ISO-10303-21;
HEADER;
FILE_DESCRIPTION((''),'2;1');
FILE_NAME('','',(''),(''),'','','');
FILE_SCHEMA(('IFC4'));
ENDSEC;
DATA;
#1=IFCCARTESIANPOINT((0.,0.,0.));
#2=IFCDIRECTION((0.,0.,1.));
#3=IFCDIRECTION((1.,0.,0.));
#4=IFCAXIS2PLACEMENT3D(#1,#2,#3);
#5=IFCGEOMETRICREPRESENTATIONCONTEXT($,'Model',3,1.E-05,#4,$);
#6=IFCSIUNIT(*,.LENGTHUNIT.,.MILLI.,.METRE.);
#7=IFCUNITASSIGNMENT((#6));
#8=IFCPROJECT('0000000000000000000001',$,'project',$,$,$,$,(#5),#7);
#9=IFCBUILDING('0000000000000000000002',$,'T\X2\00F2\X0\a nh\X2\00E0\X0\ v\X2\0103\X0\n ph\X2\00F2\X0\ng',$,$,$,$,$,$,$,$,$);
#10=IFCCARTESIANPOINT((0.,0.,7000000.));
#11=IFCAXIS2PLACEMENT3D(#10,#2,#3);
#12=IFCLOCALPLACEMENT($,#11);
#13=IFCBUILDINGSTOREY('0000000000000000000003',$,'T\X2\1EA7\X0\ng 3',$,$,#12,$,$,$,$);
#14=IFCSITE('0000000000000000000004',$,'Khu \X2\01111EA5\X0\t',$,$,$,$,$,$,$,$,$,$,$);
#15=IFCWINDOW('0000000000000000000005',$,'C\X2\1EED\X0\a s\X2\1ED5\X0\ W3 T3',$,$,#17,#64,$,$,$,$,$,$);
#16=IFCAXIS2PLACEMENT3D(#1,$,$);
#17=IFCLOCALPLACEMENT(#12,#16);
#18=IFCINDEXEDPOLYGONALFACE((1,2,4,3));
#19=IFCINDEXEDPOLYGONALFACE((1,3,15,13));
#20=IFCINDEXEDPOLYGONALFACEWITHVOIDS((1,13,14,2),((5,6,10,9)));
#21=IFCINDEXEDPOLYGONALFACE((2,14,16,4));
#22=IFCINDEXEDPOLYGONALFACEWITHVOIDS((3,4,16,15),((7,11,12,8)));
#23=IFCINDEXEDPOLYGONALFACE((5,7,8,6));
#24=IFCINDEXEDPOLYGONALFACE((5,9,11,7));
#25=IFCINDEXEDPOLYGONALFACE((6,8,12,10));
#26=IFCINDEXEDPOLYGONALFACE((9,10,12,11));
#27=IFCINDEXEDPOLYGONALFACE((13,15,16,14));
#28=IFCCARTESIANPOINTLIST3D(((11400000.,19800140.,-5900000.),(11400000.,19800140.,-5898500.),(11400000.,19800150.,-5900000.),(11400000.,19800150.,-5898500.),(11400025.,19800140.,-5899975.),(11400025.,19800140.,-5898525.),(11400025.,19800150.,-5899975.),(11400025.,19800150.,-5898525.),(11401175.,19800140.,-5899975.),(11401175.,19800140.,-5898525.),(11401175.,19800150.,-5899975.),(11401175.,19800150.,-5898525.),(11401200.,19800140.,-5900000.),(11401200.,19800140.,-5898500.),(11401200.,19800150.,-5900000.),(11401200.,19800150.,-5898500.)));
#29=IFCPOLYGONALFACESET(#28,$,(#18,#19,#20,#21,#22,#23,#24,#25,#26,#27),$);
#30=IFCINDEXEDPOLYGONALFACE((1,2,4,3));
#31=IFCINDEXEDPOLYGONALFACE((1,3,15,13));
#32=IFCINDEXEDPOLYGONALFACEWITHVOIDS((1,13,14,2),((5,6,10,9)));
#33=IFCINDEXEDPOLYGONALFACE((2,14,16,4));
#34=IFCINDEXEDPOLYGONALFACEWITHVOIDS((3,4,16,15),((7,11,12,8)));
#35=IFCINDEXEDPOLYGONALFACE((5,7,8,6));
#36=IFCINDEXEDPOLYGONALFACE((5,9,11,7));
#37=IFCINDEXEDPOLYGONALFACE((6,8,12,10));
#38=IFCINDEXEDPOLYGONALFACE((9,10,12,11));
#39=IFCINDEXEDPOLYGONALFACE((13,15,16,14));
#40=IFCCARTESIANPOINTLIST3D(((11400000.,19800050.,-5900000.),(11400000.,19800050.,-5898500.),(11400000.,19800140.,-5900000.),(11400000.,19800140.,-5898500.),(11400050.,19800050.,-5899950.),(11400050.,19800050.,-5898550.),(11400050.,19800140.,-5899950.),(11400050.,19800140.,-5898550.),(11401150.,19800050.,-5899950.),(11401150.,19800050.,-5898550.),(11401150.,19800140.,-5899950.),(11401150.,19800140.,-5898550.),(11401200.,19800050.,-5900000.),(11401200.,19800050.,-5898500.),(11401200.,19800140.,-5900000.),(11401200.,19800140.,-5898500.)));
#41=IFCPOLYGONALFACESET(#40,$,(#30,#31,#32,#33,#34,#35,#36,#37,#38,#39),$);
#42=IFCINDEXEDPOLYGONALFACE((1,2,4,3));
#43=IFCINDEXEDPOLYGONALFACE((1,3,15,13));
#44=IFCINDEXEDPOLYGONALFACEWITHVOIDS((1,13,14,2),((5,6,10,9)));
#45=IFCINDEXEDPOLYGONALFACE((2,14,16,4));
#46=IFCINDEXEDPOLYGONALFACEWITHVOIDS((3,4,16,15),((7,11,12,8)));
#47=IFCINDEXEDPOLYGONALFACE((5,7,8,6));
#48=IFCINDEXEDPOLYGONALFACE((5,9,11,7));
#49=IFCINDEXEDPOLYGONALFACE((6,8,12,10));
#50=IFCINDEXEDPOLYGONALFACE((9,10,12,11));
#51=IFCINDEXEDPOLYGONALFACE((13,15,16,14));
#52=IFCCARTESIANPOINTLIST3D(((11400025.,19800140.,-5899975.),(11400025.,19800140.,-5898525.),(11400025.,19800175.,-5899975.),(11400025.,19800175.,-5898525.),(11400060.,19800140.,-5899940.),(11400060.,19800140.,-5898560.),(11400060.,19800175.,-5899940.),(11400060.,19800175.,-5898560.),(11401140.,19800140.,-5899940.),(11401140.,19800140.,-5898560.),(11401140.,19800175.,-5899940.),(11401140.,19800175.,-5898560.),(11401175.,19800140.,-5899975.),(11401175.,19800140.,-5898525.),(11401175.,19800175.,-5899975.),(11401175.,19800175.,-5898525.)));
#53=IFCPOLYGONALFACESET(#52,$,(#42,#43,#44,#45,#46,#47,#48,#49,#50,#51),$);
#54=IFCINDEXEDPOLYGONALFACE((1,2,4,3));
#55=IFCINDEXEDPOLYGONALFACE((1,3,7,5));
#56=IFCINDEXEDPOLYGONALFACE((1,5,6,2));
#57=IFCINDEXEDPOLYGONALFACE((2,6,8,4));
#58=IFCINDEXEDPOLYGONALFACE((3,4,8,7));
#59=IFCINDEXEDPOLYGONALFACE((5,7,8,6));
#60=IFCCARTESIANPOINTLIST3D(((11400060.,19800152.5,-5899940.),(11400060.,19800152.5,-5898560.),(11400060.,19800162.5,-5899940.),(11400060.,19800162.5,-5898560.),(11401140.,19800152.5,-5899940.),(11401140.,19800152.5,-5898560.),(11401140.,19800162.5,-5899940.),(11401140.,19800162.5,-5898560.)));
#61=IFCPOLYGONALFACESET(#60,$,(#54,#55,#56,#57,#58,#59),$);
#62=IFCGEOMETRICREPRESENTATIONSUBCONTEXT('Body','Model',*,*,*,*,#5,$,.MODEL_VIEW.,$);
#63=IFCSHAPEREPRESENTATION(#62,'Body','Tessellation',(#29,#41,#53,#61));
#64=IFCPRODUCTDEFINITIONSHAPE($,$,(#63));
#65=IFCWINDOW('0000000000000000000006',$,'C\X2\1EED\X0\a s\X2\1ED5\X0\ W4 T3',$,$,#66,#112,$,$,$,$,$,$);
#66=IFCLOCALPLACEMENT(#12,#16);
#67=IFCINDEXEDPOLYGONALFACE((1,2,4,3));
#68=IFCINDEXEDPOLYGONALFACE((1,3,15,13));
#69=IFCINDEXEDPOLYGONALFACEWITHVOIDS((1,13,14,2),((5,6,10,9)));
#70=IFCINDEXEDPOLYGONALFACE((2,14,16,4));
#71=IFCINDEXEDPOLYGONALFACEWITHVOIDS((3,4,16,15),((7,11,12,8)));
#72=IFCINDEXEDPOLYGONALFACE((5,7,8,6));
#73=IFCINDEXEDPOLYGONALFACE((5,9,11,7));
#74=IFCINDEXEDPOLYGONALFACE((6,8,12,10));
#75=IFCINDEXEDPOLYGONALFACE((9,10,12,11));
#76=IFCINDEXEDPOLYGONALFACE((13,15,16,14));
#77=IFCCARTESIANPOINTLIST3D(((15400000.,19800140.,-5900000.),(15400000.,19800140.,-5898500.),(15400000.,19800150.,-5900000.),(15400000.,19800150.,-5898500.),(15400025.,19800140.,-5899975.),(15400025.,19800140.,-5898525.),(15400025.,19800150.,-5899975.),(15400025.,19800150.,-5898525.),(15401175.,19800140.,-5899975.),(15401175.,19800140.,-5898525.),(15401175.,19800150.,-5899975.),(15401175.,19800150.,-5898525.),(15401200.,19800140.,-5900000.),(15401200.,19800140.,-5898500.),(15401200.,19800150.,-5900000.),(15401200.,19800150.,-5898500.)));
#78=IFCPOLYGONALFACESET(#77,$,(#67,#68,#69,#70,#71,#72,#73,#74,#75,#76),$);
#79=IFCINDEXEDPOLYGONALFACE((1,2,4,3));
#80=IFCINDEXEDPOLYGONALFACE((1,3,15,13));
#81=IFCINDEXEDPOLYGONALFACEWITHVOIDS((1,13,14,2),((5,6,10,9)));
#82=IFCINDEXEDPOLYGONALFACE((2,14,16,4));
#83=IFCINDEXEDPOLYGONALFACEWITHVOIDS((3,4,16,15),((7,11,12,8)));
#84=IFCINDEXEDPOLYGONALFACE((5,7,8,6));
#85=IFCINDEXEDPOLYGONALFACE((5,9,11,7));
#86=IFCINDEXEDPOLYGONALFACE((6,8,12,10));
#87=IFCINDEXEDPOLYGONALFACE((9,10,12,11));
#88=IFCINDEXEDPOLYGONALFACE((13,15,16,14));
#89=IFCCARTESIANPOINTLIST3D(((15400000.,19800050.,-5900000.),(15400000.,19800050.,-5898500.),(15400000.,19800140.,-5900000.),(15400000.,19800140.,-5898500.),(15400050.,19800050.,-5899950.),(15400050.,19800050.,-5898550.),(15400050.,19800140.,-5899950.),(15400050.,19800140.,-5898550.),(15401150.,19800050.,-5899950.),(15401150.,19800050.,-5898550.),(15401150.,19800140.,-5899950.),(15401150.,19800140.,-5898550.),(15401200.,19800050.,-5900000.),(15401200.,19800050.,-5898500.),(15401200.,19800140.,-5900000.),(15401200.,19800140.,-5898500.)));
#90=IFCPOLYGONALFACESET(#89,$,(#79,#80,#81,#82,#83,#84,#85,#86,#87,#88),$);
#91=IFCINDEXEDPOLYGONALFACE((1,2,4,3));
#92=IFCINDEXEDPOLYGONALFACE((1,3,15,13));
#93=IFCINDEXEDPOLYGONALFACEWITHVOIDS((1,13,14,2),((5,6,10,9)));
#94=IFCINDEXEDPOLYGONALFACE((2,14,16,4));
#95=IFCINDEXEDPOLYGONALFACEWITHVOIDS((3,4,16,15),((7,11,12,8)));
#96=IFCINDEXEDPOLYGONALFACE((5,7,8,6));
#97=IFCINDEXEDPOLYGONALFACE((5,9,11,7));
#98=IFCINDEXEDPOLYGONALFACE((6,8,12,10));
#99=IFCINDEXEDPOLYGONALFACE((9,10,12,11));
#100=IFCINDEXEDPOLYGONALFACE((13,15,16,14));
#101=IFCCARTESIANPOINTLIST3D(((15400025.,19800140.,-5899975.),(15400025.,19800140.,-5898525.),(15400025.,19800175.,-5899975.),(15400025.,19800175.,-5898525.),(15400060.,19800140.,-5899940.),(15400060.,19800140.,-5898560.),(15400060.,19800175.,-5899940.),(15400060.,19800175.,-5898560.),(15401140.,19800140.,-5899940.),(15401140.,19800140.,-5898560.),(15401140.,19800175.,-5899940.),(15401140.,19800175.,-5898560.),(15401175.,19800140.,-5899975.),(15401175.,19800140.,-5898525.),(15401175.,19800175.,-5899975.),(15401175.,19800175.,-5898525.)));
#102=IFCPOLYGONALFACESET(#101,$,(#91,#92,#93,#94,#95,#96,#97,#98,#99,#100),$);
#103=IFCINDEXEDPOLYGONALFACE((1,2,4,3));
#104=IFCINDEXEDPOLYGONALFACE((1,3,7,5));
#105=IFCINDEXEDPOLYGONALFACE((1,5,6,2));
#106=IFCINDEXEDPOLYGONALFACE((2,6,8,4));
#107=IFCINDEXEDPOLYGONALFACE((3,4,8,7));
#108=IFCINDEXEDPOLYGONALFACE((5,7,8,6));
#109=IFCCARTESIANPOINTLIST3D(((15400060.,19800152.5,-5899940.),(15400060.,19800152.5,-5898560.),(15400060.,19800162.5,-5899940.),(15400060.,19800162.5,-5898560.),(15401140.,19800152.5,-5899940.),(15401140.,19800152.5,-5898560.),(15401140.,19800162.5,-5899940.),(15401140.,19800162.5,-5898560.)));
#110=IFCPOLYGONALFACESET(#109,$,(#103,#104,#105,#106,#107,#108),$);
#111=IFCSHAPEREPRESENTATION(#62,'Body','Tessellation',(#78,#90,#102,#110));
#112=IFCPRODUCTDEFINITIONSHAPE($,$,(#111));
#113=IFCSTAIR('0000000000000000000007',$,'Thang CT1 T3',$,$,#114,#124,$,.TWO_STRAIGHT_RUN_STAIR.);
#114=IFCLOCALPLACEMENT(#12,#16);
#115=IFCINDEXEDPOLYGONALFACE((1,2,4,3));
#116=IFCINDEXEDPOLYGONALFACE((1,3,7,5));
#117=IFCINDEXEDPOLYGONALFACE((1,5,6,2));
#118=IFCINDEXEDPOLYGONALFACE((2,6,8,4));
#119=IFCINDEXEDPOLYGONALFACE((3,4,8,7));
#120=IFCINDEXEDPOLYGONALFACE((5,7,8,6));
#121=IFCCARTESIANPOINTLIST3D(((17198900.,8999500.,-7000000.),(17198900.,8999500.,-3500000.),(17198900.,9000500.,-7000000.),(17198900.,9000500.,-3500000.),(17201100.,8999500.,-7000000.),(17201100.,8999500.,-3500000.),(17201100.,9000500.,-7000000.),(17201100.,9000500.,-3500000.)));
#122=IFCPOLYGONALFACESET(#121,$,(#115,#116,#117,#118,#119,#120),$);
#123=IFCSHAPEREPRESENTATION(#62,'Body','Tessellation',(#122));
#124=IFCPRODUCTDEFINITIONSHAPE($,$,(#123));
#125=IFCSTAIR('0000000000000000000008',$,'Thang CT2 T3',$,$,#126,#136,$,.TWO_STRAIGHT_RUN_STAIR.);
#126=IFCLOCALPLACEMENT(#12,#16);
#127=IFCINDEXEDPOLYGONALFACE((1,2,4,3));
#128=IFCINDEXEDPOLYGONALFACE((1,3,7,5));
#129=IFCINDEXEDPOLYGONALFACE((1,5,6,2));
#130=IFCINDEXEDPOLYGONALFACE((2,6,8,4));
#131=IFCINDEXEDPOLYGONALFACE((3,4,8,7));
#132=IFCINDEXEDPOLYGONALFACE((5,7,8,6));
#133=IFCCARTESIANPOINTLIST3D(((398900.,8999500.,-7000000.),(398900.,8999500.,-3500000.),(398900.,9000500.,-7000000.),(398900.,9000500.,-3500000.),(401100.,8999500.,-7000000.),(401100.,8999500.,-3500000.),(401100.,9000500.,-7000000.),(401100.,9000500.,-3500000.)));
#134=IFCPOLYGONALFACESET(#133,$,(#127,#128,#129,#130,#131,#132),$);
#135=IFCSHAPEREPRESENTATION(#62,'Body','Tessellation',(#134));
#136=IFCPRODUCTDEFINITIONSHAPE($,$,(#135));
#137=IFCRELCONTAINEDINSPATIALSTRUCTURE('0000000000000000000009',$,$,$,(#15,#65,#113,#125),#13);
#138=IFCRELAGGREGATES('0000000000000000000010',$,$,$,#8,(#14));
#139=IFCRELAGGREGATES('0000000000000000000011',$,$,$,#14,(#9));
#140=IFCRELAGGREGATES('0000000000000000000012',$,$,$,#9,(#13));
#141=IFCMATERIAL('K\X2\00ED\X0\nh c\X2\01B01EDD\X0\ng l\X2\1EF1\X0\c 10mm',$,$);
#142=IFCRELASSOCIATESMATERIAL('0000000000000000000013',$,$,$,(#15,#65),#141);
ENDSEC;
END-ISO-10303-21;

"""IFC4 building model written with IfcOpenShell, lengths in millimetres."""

from ifc_helpers import new_model, entity, si_unit, frame, origin_with_axes, place, context, subcontext, project, spatial, line, indexed_curve, outline, extrude, material, element, save


model = new_model("IFC4")

# Units and contexts
model_context = context("Model", 3, precision=1e-05, world=origin_with_axes())
body_context = subcontext(model_context, "Body", "Model", "MODEL_VIEW")
ifc_project = project(units=[si_unit("LENGTHUNIT", "METRE", prefix="MILLI")], contexts=[model_context])

# Site, building, storey
site = spatial("IfcSite", under=ifc_project, Name="Khu đất")
building = spatial("IfcBuilding", under=site, Name="Tòa nhà văn phòng")
storey_placement = place(None, frame((0.0, 0.0, 7000000.0), z_axis=(0.0, 0.0, 1.0), x_axis=(1.0, 0.0, 0.0)))
storey = spatial("IfcBuildingStorey", under=building, at=storey_placement, Name="Tầng 3")

# Windows
ifc_material_1 = material(Name="Kính cường lực 10mm")
for number, where, z_axis, x_axis, name in (
    (1, (11400000.0, 19800000.0, -5900000.0), (0.0, 0.0, 1.0), (1.0, 0.0, 0.0), "Cửa sổ W3 T3"),
    (2, (15400000.0, 19800000.0, -5900000.0), (0.0, 0.0, 1.0), (1.0, 0.0, 0.0), "Cửa sổ W4 T3"),
):
    element("IfcWindow", number, at=place(storey_placement, frame(where, z_axis=z_axis, x_axis=x_axis)), inside=storey, material=ifc_material_1, Name=name, context=body_context, shape_type="SolidModel", body=[
        extrude(outline(indexed_curve([(0.0, 0.0), (1200.0, 0.0), (1200.0, 1500.0), (0.0, 1500.0)], segments=[line(1, 2, 3, 4, 1)]), holes=[indexed_curve([(25.0, 25.0), (1175.0, 25.0), (1175.0, 1475.0), (25.0, 1475.0)], segments=[line(1, 2, 3, 4, 1)])]), frame((0.0, 140.0, 0.0), z_axis=(0.0, -1.0, 0.0), x_axis=(1.0, 0.0, 0.0)), (0.0, 0.0, -1.0), 10.0),
        extrude(outline(indexed_curve([(0.0, 0.0), (1200.0, 0.0), (1200.0, 1500.0), (0.0, 1500.0)], segments=[line(1, 2, 3, 4, 1)]), holes=[indexed_curve([(50.0, 50.0), (1150.0, 50.0), (1150.0, 1450.0), (50.0, 1450.0)], segments=[line(1, 2, 3, 4, 1)])]), frame((0.0, 50.0, 0.0), z_axis=(0.0, -1.0, 0.0), x_axis=(1.0, 0.0, 0.0)), (0.0, 0.0, -1.0), 90.0),
        extrude(outline(indexed_curve([(0.0, 0.0), (1150.0, 0.0), (1150.0, 1450.0), (0.0, 1450.0)], segments=[line(1, 2, 3, 4, 1)]), holes=[indexed_curve([(35.0, 35.0), (1115.0, 35.0), (1115.0, 1415.0), (35.0, 1415.0)], segments=[line(1, 2, 3, 4, 1)])]), frame((25.0, 140.0, 25.0), z_axis=(0.0, -1.0, 0.0), x_axis=(1.0, 0.0, 0.0)), (0.0, 0.0, -1.0), 35.0),
        extrude(outline(indexed_curve([(35.0, 35.0), (1115.0, 35.0), (1115.0, 1415.0), (35.0, 1415.0)], segments=[line(1, 2, 3, 4, 1)])), frame((25.0, 152.5, 25.0), z_axis=(0.0, -1.0, 0.0), x_axis=(1.0, 0.0, 0.0)), (0.0, 0.0, -1.0), 10.0),
    ])

# Stairs
for number, where, z_axis, x_axis, name in (
    (3, (17200000.0, 9000000.0, -7000000.0), (0.0, 0.0, 1.0), (1.0, 0.0, 0.0), "Thang CT1 T3"),
    (4, (400000.0, 9000000.0, -7000000.0), (0.0, 0.0, 1.0), (1.0, 0.0, 0.0), "Thang CT2 T3"),
):
    element("IfcStair", number, at=place(storey_placement, frame(where, z_axis=z_axis, x_axis=x_axis)), inside=storey, Name=name, PredefinedType="TWO_STRAIGHT_RUN_STAIR", context=body_context, shape_type="SweptSolid", body=[
        extrude(entity("IfcRectangleProfileDef", None, None, None, 2200.0, 1000.0), origin_with_axes(), (0.0, 0.0, 1.0), 3500000.0),
    ])

save(model, "model.ifc")
